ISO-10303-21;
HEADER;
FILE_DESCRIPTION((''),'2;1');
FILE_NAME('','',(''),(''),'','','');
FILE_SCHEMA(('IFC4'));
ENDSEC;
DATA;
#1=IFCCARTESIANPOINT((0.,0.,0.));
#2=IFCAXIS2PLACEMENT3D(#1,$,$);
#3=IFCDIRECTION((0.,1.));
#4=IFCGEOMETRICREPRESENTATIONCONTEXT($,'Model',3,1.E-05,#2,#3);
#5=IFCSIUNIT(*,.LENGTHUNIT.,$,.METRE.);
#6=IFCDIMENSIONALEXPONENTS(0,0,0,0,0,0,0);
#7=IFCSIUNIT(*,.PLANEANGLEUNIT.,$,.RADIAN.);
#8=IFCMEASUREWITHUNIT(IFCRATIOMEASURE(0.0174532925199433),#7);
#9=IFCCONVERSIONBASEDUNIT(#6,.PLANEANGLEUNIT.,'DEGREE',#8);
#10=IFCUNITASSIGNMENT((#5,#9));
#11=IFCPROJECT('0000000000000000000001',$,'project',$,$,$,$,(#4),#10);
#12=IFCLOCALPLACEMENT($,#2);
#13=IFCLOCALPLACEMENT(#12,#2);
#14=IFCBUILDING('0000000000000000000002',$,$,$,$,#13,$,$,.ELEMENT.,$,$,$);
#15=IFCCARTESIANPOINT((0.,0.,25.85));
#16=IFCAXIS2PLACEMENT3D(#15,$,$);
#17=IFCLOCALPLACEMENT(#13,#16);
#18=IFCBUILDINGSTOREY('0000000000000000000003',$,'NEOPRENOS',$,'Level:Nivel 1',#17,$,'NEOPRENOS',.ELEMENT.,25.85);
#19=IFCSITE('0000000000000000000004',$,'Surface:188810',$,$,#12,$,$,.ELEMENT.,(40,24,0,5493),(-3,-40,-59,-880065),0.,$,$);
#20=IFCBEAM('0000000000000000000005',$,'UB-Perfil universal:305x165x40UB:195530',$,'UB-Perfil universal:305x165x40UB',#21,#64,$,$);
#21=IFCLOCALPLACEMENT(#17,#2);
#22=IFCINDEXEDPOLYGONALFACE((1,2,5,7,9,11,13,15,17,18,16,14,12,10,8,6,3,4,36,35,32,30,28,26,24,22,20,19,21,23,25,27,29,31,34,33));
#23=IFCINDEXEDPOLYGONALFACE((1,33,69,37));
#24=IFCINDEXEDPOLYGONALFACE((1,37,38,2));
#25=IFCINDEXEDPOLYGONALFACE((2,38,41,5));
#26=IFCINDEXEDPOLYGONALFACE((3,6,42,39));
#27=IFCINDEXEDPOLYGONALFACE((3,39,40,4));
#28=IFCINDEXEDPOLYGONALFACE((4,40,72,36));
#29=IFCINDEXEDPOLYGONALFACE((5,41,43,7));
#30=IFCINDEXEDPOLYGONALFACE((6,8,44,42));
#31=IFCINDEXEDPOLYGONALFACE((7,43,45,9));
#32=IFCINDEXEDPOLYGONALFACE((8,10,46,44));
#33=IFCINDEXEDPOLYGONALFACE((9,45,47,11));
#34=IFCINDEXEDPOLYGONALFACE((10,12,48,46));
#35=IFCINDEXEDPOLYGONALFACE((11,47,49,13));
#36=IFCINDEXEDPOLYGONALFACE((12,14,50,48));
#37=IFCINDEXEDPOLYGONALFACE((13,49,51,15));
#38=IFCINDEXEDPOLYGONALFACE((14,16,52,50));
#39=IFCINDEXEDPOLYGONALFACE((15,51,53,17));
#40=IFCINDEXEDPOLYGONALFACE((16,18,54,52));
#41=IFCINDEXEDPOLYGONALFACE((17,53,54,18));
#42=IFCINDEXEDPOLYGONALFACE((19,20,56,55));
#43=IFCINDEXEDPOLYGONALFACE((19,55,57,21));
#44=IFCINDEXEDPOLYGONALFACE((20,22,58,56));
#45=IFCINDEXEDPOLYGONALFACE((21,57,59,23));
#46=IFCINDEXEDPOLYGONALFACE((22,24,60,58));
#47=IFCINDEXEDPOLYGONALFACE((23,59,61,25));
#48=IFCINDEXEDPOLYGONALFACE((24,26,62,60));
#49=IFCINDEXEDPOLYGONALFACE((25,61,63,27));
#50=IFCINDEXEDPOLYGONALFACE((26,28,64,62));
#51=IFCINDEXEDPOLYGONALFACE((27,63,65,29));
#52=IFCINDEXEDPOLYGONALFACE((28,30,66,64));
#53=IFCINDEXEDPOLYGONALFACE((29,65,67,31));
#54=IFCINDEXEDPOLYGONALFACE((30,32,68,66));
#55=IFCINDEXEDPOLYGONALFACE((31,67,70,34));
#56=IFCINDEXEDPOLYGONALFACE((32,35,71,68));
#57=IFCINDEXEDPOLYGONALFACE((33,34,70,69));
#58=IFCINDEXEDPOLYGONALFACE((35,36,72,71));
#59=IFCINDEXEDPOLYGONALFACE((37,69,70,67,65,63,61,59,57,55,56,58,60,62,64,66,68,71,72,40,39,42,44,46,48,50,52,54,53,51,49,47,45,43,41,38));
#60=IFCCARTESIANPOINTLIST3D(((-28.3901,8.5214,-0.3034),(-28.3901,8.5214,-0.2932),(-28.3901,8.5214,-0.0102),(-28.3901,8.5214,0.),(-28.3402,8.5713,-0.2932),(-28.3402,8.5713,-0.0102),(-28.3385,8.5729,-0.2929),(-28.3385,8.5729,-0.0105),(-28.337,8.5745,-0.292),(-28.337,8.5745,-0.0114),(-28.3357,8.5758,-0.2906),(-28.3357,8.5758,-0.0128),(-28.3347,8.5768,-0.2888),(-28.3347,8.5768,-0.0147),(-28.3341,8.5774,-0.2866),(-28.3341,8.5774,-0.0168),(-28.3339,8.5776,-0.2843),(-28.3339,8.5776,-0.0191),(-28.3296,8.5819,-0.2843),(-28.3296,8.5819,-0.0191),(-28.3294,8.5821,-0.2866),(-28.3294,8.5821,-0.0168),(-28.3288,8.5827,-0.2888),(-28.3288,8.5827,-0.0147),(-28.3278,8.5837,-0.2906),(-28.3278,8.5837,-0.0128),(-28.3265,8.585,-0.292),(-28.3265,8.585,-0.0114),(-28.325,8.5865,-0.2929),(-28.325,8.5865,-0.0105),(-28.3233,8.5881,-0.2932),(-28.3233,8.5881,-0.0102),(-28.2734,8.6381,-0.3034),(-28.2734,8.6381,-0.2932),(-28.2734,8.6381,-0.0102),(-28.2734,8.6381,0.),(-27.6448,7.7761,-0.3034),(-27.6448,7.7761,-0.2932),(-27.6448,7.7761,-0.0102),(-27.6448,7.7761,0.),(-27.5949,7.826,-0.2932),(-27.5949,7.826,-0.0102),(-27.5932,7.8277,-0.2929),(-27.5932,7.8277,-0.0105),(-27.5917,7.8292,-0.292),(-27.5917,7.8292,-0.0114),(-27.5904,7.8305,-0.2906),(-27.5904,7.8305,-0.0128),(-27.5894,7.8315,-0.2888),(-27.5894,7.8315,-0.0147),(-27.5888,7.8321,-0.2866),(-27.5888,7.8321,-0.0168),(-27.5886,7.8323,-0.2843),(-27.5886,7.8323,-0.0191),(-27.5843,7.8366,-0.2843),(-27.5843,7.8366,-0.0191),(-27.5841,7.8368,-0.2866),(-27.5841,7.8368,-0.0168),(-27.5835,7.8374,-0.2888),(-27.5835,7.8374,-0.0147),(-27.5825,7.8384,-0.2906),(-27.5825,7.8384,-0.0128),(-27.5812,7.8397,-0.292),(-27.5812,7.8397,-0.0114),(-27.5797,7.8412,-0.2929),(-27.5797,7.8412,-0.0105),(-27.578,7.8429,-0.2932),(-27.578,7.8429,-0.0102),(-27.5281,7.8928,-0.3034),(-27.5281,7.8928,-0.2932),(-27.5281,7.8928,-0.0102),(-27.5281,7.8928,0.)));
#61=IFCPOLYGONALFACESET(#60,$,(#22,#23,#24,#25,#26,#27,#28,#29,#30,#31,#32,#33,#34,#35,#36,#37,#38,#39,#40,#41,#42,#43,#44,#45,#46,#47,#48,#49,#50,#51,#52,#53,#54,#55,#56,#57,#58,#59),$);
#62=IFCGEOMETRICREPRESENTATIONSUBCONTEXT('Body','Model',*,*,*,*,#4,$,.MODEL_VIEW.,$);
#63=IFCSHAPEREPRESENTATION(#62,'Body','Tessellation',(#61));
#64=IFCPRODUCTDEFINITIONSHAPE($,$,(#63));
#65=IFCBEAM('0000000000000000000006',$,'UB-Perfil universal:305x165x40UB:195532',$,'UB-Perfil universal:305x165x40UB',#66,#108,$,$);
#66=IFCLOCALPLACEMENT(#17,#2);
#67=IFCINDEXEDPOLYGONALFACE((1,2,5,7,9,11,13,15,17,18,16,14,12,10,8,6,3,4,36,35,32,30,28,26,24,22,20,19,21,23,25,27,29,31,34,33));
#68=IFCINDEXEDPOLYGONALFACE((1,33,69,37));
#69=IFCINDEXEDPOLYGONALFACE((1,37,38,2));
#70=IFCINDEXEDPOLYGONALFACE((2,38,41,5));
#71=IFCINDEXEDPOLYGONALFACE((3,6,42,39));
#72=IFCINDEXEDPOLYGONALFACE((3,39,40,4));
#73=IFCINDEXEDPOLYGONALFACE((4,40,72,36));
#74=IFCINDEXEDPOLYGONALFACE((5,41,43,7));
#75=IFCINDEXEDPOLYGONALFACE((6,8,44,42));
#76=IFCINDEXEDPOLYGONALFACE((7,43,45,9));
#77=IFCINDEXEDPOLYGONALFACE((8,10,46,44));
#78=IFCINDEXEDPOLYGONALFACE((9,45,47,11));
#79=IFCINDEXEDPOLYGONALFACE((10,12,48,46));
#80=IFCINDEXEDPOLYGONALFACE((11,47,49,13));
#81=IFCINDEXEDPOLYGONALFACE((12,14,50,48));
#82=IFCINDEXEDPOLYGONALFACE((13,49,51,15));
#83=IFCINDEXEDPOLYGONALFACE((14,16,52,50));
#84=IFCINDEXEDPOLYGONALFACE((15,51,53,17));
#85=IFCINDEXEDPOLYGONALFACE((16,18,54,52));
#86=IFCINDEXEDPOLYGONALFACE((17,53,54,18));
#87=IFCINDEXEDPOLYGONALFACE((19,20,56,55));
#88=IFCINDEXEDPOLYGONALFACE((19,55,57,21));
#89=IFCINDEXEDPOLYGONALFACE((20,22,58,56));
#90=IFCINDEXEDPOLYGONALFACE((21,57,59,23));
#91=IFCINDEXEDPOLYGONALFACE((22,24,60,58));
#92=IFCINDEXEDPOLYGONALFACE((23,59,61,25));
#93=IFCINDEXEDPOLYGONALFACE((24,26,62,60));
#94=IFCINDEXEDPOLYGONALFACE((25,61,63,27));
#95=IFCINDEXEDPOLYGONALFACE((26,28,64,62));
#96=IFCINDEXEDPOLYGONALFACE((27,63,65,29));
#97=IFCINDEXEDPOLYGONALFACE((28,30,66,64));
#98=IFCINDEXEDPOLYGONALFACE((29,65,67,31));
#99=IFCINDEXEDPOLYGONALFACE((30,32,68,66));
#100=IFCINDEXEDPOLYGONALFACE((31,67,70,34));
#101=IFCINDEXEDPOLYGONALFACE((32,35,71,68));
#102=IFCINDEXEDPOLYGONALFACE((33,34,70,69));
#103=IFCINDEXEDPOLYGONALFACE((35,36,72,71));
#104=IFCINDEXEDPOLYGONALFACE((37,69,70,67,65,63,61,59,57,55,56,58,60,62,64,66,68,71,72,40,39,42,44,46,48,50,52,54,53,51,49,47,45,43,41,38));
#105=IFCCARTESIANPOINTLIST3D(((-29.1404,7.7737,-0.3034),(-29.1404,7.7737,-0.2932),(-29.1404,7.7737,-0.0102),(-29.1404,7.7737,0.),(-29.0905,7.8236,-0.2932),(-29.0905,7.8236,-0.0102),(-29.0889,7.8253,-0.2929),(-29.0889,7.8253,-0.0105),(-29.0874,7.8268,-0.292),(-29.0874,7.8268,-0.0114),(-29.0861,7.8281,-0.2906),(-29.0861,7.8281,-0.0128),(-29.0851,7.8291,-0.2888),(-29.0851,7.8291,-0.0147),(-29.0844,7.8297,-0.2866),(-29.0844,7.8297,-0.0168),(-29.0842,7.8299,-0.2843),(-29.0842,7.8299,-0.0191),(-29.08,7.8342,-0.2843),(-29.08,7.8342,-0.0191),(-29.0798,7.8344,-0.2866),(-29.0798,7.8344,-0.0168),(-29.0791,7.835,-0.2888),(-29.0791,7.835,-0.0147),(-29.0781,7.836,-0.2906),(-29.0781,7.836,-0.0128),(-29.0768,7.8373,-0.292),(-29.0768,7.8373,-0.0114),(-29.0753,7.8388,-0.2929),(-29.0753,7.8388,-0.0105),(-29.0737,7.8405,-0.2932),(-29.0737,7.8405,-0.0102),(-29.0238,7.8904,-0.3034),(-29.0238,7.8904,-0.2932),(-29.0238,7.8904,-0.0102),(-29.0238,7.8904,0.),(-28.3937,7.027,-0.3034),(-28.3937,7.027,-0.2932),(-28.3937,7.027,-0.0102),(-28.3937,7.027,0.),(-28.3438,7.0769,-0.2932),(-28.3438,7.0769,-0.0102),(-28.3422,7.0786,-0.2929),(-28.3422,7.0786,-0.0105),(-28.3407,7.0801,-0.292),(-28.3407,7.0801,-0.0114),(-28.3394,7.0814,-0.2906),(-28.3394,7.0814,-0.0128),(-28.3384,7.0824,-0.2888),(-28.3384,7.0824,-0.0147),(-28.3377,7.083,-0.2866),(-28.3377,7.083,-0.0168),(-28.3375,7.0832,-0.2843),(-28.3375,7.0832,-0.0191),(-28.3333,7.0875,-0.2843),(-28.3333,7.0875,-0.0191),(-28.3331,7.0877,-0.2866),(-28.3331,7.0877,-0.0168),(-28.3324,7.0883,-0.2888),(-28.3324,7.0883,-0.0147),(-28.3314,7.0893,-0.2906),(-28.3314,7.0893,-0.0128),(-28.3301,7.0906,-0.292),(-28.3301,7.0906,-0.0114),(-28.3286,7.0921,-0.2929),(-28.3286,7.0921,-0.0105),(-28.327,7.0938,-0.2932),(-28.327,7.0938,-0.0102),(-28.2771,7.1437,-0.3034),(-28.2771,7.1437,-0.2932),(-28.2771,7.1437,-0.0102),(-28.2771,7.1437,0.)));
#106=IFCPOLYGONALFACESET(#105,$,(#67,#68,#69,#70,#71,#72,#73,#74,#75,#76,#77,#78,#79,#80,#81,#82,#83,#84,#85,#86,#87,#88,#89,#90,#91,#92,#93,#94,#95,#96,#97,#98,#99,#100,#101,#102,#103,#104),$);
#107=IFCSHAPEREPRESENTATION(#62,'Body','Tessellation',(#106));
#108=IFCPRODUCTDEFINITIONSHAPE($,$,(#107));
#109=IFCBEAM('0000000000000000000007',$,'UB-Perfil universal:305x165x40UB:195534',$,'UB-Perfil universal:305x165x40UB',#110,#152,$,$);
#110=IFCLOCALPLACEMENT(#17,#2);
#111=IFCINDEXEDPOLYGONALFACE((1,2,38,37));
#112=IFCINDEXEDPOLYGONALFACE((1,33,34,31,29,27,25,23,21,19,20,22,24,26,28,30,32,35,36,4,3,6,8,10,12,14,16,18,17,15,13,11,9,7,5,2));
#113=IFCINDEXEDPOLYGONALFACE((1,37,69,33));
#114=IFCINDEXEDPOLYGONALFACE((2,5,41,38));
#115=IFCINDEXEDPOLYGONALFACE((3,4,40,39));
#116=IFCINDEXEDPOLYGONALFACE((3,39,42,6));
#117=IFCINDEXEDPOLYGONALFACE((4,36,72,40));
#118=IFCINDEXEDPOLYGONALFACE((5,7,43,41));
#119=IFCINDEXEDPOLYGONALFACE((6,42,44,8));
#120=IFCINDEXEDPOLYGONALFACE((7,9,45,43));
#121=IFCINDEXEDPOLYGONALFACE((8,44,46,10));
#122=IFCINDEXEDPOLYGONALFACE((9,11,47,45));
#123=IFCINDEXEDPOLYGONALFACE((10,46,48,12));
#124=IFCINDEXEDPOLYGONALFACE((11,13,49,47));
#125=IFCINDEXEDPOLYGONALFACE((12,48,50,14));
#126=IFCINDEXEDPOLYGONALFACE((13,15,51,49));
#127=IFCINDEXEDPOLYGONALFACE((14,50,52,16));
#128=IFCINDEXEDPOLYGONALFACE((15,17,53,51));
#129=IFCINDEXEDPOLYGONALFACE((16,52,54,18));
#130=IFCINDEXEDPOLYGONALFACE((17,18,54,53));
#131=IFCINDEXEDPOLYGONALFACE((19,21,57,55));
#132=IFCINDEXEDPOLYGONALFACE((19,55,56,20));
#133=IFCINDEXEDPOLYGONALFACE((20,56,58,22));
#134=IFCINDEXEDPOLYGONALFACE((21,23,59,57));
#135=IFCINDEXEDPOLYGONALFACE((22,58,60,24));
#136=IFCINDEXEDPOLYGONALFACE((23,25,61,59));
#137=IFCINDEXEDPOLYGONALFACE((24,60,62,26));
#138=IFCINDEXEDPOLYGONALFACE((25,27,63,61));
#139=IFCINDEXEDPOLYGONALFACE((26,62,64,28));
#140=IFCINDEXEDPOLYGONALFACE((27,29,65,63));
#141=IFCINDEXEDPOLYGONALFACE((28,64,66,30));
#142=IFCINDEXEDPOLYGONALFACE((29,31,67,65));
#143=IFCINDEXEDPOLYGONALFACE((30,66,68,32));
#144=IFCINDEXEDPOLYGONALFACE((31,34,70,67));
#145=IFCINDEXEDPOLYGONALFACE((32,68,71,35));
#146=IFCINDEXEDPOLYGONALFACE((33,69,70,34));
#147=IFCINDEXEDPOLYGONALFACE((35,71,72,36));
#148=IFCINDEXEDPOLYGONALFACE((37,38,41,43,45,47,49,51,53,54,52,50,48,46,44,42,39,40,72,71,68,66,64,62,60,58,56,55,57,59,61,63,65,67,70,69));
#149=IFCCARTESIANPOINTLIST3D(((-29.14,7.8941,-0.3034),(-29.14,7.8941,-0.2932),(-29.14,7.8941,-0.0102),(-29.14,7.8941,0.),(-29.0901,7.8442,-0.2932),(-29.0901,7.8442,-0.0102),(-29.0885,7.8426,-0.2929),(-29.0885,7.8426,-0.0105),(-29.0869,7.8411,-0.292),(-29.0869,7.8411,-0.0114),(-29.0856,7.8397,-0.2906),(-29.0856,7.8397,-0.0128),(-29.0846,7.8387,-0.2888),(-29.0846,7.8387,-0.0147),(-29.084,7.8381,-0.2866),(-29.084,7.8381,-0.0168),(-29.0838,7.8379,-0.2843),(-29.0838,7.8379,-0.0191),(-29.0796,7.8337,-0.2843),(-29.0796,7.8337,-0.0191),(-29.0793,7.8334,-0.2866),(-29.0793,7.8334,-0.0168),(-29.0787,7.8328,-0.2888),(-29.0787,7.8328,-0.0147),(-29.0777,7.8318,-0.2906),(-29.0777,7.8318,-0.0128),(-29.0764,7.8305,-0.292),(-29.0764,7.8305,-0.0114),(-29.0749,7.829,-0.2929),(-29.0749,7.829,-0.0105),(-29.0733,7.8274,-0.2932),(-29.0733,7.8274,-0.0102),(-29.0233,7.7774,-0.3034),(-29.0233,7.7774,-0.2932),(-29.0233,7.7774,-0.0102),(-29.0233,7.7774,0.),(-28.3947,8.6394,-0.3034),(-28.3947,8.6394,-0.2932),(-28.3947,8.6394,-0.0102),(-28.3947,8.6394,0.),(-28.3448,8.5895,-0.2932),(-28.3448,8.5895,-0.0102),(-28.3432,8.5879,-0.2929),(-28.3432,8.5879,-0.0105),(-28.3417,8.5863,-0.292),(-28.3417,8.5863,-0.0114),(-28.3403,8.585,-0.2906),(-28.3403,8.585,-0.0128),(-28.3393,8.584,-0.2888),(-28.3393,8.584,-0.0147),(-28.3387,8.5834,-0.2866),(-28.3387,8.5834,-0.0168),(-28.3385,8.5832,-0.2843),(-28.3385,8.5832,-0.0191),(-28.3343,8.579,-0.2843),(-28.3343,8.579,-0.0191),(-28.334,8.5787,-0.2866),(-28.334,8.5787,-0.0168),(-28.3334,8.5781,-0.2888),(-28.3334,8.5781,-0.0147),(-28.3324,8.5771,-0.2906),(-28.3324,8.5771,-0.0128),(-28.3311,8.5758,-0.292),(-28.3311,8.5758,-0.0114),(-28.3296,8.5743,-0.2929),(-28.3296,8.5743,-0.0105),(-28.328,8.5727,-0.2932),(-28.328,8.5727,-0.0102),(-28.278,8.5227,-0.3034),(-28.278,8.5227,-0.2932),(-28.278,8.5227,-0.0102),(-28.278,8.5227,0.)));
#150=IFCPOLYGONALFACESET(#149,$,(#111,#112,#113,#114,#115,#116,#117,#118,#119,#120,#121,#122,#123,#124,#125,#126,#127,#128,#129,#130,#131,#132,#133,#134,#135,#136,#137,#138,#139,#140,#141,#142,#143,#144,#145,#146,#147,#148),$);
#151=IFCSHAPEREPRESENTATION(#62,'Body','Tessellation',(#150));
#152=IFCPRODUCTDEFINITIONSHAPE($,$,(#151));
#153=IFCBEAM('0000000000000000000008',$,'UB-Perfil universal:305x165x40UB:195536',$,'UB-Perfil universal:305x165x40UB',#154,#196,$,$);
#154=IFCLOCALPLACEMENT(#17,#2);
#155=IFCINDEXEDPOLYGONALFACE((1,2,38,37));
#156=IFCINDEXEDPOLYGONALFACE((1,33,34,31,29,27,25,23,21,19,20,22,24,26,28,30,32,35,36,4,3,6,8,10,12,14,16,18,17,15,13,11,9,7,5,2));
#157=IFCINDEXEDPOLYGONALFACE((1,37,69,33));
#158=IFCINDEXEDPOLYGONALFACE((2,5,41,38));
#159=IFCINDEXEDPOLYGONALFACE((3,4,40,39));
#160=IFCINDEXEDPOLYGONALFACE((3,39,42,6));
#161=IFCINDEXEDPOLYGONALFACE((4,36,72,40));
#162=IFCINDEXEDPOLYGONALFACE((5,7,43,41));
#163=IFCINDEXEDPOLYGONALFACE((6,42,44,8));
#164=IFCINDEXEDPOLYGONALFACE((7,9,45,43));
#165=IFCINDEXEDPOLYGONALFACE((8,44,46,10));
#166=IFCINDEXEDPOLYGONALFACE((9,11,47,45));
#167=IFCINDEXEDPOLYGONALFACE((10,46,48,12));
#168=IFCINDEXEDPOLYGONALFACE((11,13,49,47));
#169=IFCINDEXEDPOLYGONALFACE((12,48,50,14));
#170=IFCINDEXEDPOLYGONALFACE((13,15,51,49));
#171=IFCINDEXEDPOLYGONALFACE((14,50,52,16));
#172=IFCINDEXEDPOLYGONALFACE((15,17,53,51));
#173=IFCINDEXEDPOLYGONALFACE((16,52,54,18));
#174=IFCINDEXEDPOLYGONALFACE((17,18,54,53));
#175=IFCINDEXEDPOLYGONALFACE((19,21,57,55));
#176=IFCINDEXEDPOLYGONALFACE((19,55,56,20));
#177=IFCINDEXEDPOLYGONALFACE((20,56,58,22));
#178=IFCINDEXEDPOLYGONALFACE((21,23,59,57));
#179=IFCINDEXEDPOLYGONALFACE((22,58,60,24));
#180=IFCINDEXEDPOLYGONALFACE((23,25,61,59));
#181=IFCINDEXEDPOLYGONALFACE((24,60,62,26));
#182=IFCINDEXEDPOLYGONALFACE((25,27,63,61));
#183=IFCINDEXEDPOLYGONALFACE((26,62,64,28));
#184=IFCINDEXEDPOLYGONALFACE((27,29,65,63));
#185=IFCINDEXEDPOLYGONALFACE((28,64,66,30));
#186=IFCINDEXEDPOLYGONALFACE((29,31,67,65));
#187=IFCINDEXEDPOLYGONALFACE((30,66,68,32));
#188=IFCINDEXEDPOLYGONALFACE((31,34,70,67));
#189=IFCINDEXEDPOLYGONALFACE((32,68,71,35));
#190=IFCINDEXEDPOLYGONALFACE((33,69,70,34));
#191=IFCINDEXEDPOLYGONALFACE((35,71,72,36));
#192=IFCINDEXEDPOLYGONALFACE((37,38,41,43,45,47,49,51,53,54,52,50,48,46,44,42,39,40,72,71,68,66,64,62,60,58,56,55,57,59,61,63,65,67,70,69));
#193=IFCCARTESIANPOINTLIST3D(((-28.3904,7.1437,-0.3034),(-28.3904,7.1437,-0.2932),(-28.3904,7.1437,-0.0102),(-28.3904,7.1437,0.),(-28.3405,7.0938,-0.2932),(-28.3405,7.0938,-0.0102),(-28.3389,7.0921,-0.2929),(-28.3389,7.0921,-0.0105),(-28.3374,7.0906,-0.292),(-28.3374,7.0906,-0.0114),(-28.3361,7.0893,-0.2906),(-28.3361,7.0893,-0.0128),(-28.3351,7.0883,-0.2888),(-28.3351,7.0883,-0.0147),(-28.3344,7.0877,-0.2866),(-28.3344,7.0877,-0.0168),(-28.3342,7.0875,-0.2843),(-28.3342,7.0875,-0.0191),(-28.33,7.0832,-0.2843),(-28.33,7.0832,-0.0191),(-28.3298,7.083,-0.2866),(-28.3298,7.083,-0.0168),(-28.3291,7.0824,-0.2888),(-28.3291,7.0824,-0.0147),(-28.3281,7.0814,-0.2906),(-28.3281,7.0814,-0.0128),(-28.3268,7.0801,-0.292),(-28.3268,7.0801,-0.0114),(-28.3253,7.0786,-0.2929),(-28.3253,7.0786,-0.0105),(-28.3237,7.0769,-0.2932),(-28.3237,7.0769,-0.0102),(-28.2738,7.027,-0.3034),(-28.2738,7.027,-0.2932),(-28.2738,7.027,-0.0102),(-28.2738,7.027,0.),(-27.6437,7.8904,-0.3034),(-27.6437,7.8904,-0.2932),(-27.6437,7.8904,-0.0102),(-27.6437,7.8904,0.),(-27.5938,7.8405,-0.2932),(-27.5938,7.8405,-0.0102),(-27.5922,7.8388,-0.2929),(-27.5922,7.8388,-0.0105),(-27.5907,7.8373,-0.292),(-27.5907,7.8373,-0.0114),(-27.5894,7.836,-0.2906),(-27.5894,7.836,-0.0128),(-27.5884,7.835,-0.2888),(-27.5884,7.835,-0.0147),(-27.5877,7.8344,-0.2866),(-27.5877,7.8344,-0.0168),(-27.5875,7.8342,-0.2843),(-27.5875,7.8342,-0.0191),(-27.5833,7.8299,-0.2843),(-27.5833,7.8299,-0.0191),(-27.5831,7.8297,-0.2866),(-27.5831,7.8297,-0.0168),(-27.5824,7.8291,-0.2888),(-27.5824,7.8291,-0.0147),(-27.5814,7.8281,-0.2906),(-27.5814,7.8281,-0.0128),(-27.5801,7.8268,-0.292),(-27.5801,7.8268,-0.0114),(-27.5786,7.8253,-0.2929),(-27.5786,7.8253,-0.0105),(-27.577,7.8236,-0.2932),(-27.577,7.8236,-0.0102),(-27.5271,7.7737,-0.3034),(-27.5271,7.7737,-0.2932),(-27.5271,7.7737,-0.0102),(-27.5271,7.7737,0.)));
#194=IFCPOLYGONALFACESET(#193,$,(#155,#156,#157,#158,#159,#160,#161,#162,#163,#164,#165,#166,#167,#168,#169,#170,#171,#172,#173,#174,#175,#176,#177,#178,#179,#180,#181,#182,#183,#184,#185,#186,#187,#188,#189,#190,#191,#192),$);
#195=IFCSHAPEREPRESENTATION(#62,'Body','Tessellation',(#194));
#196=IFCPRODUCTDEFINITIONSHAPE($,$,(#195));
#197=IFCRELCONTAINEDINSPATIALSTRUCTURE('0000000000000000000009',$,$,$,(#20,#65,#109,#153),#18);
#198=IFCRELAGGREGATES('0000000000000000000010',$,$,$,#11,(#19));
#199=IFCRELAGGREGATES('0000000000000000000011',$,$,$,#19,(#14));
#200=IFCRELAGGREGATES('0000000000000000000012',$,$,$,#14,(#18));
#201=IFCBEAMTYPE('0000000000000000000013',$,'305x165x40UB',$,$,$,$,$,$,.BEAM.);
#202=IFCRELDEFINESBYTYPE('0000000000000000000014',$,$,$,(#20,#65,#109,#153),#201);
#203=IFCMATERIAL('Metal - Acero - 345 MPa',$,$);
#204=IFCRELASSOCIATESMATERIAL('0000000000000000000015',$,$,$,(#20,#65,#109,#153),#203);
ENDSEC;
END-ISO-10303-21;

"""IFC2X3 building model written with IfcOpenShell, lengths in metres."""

from ifc_helpers import new_model, entity, si_unit, converted_unit, direction, frame, frame_2d, origin, place, context, subcontext, project, spatial, i_section, extrude, material, type_object, element, save


model = new_model("IFC2X3")

# Units and contexts
model_context = context("Model", 3, precision=1e-05, world=origin(), true_north=direction((0.0, 1.0)))
body_context = subcontext(model_context, "Body", "Model", "MODEL_VIEW")
ifc_project = project(units=[si_unit("LENGTHUNIT", "METRE"), converted_unit("PLANEANGLEUNIT", "DEGREE", entity("IfcRatioMeasure", 0.0174532925199433), si_unit("PLANEANGLEUNIT", "RADIAN"), dimensions=[0, 0, 0, 0, 0, 0, 0])], contexts=[model_context])

# Site, building, storey
site_placement = place(None, origin())
site = spatial("IfcSite", under=ifc_project, at=site_placement, Name="Surface:188810", CompositionType="ELEMENT", RefLatitude=(40, 24, 0, 5493), RefLongitude=(-3, -40, -59, -880065), RefElevation=0.0)
building_placement = place(site_placement, origin())
building = spatial("IfcBuilding", under=site, at=building_placement, CompositionType="ELEMENT")
storey_placement = place(building_placement, frame((0.0, 0.0, 25.85)))
storey = spatial("IfcBuildingStorey", under=building, at=storey_placement, Name="NEOPRENOS", ObjectType="Level:Nivel 1", LongName="NEOPRENOS", CompositionType="ELEMENT", Elevation=25.85)

# Beams
ifc_material_1 = material(Name="Metal - Acero - 345 MPa")
beam_type = type_object("IfcBeamType", Name="305x165x40UB", PredefinedType="BEAM")
beam_1_placement = place(storey_placement, frame((-28.3337, 8.5817, 0.0), z_axis=(0.0, 0.0, 1.0), x_axis=(0.707107, -0.707107, 0.0)))
element("IfcBeam", 1, at=beam_1_placement, inside=storey, type_object=beam_type, material=ifc_material_1, Name="UB-Perfil universal:305x165x40UB:195530", ObjectType="UB-Perfil universal:305x165x40UB", context=body_context, shape_type="SweptSolid", body=[
    extrude(i_section(OverallWidth=0.165, OverallDepth=0.3034, WebThickness=0.006, FlangeThickness=0.0102, FilletRadius=0.0089, at=frame_2d((0.0, 0.0), x_axis=(0.0, 1.0))), frame((0.0028, 0.0, -0.1517), z_axis=(1.0, 0.0, 0.0), x_axis=(0.0, 0.0, -1.0)), (0.0, 0.0, 1.0), 1.054),
])
beam_2_placement = place(storey_placement, frame((-28.3337, 7.0837, 0.0), z_axis=(0.0, 0.0, 1.0), x_axis=(-0.707107, 0.707107, 0.0)))
element("IfcBeam", 2, at=beam_2_placement, inside=storey, type_object=beam_type, material=ifc_material_1, Name="UB-Perfil universal:305x165x40UB:195532", ObjectType="UB-Perfil universal:305x165x40UB", context=body_context, shape_type="SweptSolid", body=[
    extrude(i_section(OverallWidth=0.165, OverallDepth=0.3034, WebThickness=0.006, FlangeThickness=0.0102, FilletRadius=0.0089, at=frame_2d((0.0, 0.0), x_axis=(0.0, 1.0))), frame((0.0023, 0.0, -0.1517), z_axis=(1.0, 0.0, 0.0), x_axis=(0.0, 0.0, -1.0)), (0.0, 0.0, 1.0), 1.056),
])
beam_3_placement = place(storey_placement, frame((-29.0837, 7.8337, 0.0), z_axis=(0.0, 0.0, 1.0), x_axis=(0.707107, 0.707107, 0.0)))
element("IfcBeam", 3, at=beam_3_placement, inside=storey, type_object=beam_type, material=ifc_material_1, Name="UB-Perfil universal:305x165x40UB:195534", ObjectType="UB-Perfil universal:305x165x40UB", context=body_context, shape_type="SweptSolid", body=[
    extrude(i_section(OverallWidth=0.165, OverallDepth=0.3034, WebThickness=0.006, FlangeThickness=0.0102, FilletRadius=0.0089, at=frame_2d((0.0, 0.0), x_axis=(0.0, 1.0))), frame((0.0029, 0.0, -0.1517), z_axis=(1.0, 0.0, 0.0), x_axis=(0.0, 0.0, -1.0)), (0.0, 0.0, 1.0), 1.054),
])
beam_4_placement = place(storey_placement, frame((-27.5837, 7.8337, 0.0), z_axis=(0.0, 0.0, 1.0), x_axis=(-0.707107, -0.707107, 0.0)))
element("IfcBeam", 4, at=beam_4_placement, inside=storey, type_object=beam_type, material=ifc_material_1, Name="UB-Perfil universal:305x165x40UB:195536", ObjectType="UB-Perfil universal:305x165x40UB", context=body_context, shape_type="SweptSolid", body=[
    extrude(i_section(OverallWidth=0.165, OverallDepth=0.3034, WebThickness=0.006, FlangeThickness=0.0102, FilletRadius=0.0089, at=frame_2d((0.0, 0.0), x_axis=(0.0, 1.0))), frame((0.0023, 0.0, -0.1517), z_axis=(1.0, 0.0, 0.0), x_axis=(0.0, 0.0, -1.0)), (0.0, 0.0, 1.0), 1.056),
])

save(model, "model.ifc")
